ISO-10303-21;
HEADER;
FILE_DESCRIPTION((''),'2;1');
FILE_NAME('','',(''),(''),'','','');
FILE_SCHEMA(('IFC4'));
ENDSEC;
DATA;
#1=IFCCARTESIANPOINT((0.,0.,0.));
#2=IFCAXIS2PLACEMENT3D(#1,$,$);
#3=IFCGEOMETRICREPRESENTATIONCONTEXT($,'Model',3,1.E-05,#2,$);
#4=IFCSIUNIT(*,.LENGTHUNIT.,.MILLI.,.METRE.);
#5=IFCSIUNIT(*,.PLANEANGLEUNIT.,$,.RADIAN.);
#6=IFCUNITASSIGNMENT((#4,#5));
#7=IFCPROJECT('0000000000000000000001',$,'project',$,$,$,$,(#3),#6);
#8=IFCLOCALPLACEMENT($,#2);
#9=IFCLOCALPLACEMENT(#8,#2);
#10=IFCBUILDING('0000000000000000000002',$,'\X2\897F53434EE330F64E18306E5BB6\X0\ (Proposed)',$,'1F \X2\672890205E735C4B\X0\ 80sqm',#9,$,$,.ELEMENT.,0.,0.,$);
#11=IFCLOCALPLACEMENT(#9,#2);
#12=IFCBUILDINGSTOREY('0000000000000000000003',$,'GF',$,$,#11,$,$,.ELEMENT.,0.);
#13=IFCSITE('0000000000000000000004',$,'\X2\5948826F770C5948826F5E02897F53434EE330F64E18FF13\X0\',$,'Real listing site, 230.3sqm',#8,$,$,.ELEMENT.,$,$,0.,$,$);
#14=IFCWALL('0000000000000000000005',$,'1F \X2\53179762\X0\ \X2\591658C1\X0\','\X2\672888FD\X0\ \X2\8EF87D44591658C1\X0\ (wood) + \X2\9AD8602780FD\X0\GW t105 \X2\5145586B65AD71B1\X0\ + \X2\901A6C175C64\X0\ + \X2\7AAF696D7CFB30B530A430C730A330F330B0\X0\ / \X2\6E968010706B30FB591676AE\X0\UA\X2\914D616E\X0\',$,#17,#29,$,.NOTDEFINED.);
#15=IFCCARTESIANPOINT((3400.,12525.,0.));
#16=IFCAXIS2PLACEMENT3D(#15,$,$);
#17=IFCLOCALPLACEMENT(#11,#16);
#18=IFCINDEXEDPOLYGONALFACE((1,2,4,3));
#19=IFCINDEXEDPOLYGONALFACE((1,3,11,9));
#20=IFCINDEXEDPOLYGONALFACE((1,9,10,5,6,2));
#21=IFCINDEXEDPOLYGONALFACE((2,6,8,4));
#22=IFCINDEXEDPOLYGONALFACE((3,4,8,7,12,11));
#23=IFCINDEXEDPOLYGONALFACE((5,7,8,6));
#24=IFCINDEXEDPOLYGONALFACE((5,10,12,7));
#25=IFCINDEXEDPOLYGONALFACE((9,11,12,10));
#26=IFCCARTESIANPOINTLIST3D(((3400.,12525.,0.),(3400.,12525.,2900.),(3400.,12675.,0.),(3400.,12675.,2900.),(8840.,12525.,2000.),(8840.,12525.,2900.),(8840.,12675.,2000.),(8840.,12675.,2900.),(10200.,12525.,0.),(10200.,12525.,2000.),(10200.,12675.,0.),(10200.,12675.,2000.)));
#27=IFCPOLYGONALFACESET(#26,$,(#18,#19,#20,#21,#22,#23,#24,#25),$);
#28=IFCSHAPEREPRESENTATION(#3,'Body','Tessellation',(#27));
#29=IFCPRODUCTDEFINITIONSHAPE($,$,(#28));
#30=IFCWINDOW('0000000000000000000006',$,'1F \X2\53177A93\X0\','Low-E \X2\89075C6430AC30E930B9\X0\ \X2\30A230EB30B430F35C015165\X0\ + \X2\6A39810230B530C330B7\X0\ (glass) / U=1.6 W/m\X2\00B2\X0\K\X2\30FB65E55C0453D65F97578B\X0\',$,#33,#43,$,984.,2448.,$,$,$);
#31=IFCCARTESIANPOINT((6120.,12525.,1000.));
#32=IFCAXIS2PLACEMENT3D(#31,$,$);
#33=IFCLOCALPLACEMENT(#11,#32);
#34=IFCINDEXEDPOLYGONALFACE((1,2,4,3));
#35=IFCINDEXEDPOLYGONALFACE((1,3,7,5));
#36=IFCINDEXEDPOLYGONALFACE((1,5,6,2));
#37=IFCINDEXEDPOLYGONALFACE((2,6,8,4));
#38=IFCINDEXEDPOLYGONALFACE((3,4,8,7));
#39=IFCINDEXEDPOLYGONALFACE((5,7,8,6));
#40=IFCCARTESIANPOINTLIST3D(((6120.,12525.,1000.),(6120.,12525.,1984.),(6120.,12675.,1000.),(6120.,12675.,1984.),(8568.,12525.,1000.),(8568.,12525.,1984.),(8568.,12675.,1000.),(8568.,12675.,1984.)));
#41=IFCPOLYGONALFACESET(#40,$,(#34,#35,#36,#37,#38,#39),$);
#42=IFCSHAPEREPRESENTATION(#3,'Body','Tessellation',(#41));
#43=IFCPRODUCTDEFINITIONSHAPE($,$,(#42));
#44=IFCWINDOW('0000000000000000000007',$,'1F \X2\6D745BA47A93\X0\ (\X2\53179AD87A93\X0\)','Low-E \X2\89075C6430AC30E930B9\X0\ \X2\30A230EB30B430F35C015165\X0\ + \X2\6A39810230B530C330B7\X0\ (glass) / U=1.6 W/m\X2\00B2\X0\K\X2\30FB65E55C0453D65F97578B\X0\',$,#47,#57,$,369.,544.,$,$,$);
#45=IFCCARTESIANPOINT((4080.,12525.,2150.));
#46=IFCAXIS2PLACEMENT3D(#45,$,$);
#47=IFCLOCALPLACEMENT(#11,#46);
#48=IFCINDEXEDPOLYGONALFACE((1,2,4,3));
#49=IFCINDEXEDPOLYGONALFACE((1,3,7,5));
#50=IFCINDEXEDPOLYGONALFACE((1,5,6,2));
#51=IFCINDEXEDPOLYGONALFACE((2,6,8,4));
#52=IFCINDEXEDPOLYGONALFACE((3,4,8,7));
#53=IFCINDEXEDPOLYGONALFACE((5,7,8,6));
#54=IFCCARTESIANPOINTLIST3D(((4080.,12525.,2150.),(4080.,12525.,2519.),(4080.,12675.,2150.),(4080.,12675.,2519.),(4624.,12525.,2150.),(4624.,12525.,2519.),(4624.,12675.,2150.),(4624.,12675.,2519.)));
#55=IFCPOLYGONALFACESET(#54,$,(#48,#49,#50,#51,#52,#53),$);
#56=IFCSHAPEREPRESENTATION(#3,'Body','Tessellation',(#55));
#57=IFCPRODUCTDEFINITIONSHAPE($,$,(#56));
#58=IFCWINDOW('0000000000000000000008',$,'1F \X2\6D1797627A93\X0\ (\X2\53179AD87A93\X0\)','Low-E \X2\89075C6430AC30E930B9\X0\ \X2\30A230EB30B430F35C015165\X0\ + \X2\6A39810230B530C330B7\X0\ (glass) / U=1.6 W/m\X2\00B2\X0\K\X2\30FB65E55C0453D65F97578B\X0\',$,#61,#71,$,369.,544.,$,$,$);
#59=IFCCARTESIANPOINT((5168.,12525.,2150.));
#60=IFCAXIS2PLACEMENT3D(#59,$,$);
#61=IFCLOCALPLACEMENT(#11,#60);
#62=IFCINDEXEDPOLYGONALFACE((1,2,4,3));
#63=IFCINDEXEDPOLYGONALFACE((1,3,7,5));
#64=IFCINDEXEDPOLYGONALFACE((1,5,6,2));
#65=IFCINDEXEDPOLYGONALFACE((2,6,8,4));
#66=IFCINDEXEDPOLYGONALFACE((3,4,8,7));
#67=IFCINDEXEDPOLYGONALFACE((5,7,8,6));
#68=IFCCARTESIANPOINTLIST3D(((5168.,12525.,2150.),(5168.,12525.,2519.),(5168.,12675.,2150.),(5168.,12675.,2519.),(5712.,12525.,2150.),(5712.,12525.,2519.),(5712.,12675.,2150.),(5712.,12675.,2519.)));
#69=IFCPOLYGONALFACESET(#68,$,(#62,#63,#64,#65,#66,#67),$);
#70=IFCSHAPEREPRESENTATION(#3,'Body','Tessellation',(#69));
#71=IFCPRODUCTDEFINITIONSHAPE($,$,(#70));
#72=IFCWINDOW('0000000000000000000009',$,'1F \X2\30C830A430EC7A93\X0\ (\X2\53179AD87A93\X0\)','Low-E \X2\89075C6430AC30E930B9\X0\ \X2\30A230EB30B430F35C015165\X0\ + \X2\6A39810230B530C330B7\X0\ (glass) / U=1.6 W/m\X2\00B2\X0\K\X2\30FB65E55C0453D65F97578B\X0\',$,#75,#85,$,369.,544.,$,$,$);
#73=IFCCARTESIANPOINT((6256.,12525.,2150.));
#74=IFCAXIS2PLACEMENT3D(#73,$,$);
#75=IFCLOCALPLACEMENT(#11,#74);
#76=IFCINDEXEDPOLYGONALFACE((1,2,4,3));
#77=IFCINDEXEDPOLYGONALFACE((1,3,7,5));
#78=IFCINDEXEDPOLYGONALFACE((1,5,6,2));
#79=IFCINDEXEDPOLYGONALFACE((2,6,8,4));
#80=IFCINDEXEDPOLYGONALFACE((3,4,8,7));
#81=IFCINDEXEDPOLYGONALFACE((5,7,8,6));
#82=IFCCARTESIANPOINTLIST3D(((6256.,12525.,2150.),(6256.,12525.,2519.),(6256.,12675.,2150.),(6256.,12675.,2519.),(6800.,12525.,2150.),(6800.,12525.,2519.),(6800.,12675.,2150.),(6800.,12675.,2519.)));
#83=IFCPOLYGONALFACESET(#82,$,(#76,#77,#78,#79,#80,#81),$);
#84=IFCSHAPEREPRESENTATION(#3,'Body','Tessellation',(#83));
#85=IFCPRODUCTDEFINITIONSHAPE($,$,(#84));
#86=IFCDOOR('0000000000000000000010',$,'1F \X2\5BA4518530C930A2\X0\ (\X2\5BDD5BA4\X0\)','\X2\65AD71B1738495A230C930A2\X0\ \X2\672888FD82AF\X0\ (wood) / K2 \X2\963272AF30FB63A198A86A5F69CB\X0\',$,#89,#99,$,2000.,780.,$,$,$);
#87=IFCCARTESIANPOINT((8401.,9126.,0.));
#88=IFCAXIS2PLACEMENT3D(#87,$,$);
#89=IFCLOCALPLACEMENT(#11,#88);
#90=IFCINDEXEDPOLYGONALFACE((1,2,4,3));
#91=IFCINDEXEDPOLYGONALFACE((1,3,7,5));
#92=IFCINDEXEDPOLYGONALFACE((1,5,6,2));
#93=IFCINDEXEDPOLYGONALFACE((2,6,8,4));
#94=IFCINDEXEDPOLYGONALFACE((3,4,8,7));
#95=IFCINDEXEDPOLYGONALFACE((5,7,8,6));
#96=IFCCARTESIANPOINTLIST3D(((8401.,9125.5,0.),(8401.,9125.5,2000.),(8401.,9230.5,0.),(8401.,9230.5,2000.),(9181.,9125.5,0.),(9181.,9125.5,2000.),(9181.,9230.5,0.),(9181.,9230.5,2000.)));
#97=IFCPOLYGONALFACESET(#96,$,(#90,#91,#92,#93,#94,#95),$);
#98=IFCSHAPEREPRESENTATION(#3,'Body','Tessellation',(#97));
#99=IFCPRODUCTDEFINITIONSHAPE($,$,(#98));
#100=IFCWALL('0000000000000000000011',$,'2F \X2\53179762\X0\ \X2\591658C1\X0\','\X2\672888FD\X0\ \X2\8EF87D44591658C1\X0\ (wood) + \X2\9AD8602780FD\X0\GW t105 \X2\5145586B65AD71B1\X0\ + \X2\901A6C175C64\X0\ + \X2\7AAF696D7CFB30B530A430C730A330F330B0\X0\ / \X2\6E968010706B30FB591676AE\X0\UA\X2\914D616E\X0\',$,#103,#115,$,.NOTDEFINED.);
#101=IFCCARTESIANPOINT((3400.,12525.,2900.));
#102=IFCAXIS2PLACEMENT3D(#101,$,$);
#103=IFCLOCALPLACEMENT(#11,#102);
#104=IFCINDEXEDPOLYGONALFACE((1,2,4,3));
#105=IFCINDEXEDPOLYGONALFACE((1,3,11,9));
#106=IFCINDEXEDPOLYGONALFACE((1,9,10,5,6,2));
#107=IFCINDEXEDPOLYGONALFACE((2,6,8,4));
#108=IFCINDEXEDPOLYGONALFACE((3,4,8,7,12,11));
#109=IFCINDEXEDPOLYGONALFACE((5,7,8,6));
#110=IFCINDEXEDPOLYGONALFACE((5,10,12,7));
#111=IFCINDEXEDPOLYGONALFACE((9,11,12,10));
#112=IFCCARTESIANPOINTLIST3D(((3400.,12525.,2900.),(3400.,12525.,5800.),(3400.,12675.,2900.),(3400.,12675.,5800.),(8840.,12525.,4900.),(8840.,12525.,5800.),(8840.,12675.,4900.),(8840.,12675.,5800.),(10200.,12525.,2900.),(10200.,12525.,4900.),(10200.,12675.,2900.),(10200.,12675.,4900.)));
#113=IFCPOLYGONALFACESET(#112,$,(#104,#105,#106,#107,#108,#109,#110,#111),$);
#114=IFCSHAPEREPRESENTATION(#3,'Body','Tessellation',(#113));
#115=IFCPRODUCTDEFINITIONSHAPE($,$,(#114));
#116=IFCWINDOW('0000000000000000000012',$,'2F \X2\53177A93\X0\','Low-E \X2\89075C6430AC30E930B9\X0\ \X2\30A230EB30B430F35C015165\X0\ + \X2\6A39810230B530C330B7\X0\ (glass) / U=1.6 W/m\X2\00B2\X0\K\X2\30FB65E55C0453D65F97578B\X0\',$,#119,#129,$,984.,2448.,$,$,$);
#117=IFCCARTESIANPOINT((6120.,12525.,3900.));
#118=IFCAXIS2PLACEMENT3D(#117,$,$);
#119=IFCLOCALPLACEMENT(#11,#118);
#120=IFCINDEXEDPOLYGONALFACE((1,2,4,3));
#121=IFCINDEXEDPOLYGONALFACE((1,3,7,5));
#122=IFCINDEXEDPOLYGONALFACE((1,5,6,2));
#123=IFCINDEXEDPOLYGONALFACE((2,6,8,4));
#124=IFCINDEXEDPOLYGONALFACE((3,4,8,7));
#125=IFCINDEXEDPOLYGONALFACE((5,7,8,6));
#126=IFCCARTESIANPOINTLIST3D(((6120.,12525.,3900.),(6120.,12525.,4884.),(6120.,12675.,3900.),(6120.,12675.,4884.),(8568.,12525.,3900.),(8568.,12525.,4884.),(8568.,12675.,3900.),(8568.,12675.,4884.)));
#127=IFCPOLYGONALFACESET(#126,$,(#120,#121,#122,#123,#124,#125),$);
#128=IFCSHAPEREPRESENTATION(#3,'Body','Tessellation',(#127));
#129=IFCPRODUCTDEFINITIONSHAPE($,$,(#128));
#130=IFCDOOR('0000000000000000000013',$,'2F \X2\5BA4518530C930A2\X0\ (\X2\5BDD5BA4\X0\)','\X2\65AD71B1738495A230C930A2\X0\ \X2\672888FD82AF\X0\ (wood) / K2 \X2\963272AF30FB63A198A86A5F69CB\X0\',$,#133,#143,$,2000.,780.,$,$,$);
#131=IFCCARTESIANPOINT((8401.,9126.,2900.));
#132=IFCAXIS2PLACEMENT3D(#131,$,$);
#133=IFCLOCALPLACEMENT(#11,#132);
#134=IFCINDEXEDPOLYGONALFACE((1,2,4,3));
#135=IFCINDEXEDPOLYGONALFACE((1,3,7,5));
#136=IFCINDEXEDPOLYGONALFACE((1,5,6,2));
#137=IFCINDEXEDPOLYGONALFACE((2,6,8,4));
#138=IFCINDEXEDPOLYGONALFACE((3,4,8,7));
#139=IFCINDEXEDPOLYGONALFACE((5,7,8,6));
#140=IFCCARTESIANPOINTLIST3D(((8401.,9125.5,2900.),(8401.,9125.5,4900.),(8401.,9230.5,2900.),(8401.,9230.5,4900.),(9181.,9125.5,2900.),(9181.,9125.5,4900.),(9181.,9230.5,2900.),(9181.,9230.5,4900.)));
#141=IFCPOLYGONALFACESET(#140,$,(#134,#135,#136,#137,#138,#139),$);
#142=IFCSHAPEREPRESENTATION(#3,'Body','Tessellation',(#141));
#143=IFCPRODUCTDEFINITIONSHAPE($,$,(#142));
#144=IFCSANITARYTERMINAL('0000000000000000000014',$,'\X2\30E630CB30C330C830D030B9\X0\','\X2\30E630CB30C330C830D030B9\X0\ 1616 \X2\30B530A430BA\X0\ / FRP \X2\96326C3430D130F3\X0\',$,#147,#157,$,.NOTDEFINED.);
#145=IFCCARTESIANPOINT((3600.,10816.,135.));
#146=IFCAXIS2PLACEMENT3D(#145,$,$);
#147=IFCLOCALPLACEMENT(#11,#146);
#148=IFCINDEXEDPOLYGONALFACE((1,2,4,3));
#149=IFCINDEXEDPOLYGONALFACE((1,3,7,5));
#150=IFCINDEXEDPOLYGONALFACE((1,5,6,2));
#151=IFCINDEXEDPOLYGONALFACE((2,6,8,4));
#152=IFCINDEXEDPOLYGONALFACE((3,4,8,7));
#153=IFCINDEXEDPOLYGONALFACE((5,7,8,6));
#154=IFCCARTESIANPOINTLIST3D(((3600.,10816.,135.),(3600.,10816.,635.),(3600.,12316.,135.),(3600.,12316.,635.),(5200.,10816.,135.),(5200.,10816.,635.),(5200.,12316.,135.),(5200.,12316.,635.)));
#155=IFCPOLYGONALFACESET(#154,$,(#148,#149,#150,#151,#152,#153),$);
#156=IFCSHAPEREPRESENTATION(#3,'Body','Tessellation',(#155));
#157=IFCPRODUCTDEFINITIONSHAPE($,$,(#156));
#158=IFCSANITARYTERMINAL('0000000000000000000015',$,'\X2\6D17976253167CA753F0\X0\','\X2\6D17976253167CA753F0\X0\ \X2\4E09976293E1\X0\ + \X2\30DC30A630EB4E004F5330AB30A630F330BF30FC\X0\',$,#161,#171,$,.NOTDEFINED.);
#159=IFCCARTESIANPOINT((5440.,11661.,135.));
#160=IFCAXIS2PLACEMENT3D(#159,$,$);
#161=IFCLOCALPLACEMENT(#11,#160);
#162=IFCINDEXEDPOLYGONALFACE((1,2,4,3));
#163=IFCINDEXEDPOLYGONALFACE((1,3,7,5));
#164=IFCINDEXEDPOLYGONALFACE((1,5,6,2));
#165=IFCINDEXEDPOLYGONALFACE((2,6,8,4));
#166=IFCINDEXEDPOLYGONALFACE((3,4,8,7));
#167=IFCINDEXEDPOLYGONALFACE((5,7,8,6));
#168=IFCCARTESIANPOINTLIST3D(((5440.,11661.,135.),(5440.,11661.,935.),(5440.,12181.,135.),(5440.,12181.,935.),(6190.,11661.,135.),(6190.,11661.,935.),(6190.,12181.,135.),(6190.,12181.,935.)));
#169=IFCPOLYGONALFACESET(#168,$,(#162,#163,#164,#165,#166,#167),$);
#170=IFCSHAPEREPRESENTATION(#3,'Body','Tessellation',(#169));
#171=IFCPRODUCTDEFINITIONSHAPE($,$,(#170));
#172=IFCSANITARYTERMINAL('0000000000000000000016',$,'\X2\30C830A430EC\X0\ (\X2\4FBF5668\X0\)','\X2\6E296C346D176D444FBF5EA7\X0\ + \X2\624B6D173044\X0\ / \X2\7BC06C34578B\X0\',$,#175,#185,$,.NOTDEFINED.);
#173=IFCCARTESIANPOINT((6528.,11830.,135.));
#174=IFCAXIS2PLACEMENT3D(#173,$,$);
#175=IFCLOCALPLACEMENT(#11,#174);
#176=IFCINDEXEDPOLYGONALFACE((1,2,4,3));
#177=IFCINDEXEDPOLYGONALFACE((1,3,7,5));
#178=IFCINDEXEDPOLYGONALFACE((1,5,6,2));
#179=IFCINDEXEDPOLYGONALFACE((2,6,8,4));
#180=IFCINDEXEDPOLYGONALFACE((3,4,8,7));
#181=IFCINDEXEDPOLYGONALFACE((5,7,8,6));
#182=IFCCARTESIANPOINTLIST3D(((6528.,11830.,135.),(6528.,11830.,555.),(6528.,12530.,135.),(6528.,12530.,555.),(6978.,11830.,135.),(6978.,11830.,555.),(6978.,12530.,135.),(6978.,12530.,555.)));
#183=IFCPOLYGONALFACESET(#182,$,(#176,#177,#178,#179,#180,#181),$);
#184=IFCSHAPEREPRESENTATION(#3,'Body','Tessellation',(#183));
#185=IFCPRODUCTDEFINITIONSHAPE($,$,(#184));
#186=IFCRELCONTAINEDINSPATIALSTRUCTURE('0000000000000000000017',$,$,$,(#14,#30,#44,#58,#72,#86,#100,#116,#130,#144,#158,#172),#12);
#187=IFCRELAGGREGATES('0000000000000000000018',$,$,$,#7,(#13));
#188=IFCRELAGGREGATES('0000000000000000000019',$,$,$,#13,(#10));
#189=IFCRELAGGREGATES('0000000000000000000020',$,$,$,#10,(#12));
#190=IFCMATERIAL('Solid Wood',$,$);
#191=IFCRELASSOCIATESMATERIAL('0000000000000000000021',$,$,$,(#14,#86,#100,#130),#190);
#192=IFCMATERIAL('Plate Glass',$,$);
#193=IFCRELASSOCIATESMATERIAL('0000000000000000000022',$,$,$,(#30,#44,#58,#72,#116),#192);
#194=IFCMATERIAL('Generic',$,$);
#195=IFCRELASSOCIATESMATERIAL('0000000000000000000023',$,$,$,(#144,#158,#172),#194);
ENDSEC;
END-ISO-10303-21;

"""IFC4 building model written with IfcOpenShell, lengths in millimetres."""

from ifc_helpers import new_model, si_unit, frame, frame_2d, origin, place, context, project, spatial, rectangle, extrude, material, element, fill, save


model = new_model("IFC4")

# Units and contexts
model_context = context("Model", 3, precision=1e-05, world=origin())
ifc_project = project(units=[si_unit("LENGTHUNIT", "METRE", prefix="MILLI"), si_unit("PLANEANGLEUNIT", "RADIAN")], contexts=[model_context])

# Site, building, storey
site_placement = place(None, origin())
site = spatial("IfcSite", under=ifc_project, at=site_placement, Name="奈良県奈良市西千代ヶ丘３", ObjectType="Real listing site, 230.3sqm", CompositionType="ELEMENT", RefElevation=0.0)
building_placement = place(site_placement, origin())
building = spatial("IfcBuilding", under=site, at=building_placement, Name="西千代ヶ丘の家 (Proposed)", ObjectType="1F 木造平屋 80sqm", CompositionType="ELEMENT", ElevationOfRefHeight=0.0, ElevationOfTerrain=0.0)
storey_placement = place(building_placement, origin())
storey = spatial("IfcBuildingStorey", under=building, at=storey_placement, Name="GF", CompositionType="ELEMENT", Elevation=0.0)

# Wall, openings, windows
ifc_material_1 = material(Name="Solid Wood")
wall_1_placement = place(storey_placement, frame((3400.0, 12525.0, 0.0)))
wall_1 = element("IfcWall", 1, at=wall_1_placement, inside=storey, material=ifc_material_1, Name="1F 北面 外壁", Description="木製 軸組外壁 (wood) + 高性能GW t105 充填断熱 + 通気層 + 窯業系サイディング / 準耐火・外皮UA配慮", PredefinedType="NOTDEFINED", context=model_context, shape_type="SweptSolid", body=[
    extrude(rectangle(XDim=6800.0, YDim=150.0, at=frame_2d((3400.0, 75.0))), frame((3400.0, 12525.0, 0.0)), (0.0, 0.0, 1.0), 2900.0),
])
opening_1_placement = place(storey_placement, frame((6120.0, 12525.0, 1000.0)))
opening_1 = element("IfcOpeningElement", 2, at=opening_1_placement, cuts=wall_1, PredefinedType="NOTDEFINED", context=model_context, shape_type="SweptSolid", body=[
    extrude(rectangle(XDim=2448.0, YDim=150.0, at=frame_2d((1224.0, 75.0))), frame((6120.0, 12525.0, 1000.0)), (0.0, 0.0, 1.0), 984.0),
])
opening_2_placement = place(storey_placement, frame((4080.0, 12525.0, 2150.0)))
opening_2 = element("IfcOpeningElement", 3, at=opening_2_placement, cuts=wall_1, PredefinedType="NOTDEFINED", context=model_context, shape_type="SweptSolid", body=[
    extrude(rectangle(XDim=544.0, YDim=150.0, at=frame_2d((272.0, 75.0))), frame((4080.0, 12525.0, 2150.0)), (0.0, 0.0, 1.0), 369.0),
])
opening_3_placement = place(storey_placement, frame((5168.0, 12525.0, 2150.0)))
opening_3 = element("IfcOpeningElement", 4, at=opening_3_placement, cuts=wall_1, PredefinedType="NOTDEFINED", context=model_context, shape_type="SweptSolid", body=[
    extrude(rectangle(XDim=544.0, YDim=150.0, at=frame_2d((272.0, 75.0))), frame((5168.0, 12525.0, 2150.0)), (0.0, 0.0, 1.0), 369.0),
])
opening_4_placement = place(storey_placement, frame((6256.0, 12525.0, 2150.0)))
opening_4 = element("IfcOpeningElement", 5, at=opening_4_placement, cuts=wall_1, PredefinedType="NOTDEFINED", context=model_context, shape_type="SweptSolid", body=[
    extrude(rectangle(XDim=544.0, YDim=150.0, at=frame_2d((272.0, 75.0))), frame((6256.0, 12525.0, 2150.0)), (0.0, 0.0, 1.0), 369.0),
])
ifc_material_2 = material(Name="Plate Glass")
window_1_placement = place(storey_placement, frame((6120.0, 12525.0, 1000.0)))
window_1 = element("IfcWindow", 6, at=window_1_placement, inside=storey, material=ifc_material_2, Name="1F 北窓", Description="Low-E 複層ガラス アルゴン封入 + 樹脂サッシ (glass) / U=1.6 W/m²K・日射取得型", OverallHeight=984.0, OverallWidth=2448.0, context=model_context, shape_type="SweptSolid", body=[
    extrude(rectangle(XDim=2448.0, YDim=150.0, at=frame_2d((1224.0, 75.0))), frame((6120.0, 12525.0, 1000.0)), (0.0, 0.0, 1.0), 984.0),
])
fill(opening_1, window_1)
window_2_placement = place(storey_placement, frame((4080.0, 12525.0, 2150.0)))
window_2 = element("IfcWindow", 7, at=window_2_placement, inside=storey, material=ifc_material_2, Name="1F 浴室窓 (北高窓)", Description="Low-E 複層ガラス アルゴン封入 + 樹脂サッシ (glass) / U=1.6 W/m²K・日射取得型", OverallHeight=369.0, OverallWidth=544.0, context=model_context, shape_type="SweptSolid", body=[
    extrude(rectangle(XDim=544.0, YDim=150.0, at=frame_2d((272.0, 75.0))), frame((4080.0, 12525.0, 2150.0)), (0.0, 0.0, 1.0), 369.0),
])
fill(opening_2, window_2)
window_3_placement = place(storey_placement, frame((5168.0, 12525.0, 2150.0)))
window_3 = element("IfcWindow", 8, at=window_3_placement, inside=storey, material=ifc_material_2, Name="1F 洗面窓 (北高窓)", Description="Low-E 複層ガラス アルゴン封入 + 樹脂サッシ (glass) / U=1.6 W/m²K・日射取得型", OverallHeight=369.0, OverallWidth=544.0, context=model_context, shape_type="SweptSolid", body=[
    extrude(rectangle(XDim=544.0, YDim=150.0, at=frame_2d((272.0, 75.0))), frame((5168.0, 12525.0, 2150.0)), (0.0, 0.0, 1.0), 369.0),
])
fill(opening_3, window_3)
window_4_placement = place(storey_placement, frame((6256.0, 12525.0, 2150.0)))
window_4 = element("IfcWindow", 9, at=window_4_placement, inside=storey, material=ifc_material_2, Name="1F トイレ窓 (北高窓)", Description="Low-E 複層ガラス アルゴン封入 + 樹脂サッシ (glass) / U=1.6 W/m²K・日射取得型", OverallHeight=369.0, OverallWidth=544.0, context=model_context, shape_type="SweptSolid", body=[
    extrude(rectangle(XDim=544.0, YDim=150.0, at=frame_2d((272.0, 75.0))), frame((6256.0, 12525.0, 2150.0)), (0.0, 0.0, 1.0), 369.0),
])
fill(opening_4, window_4)

# Door
door_1_placement = place(storey_placement, frame((8401.0, 9126.0, 0.0)))
element("IfcDoor", 10, at=door_1_placement, inside=storey, material=ifc_material_1, Name="1F 室内ドア (寝室)", Description="断熱玄関ドア 木製芯 (wood) / K2 防犯・採風機構", OverallHeight=2000.0, OverallWidth=780.0, context=model_context, shape_type="SweptSolid", body=[
    extrude(rectangle(XDim=780.0, YDim=105.0, at=frame_2d((390.0, 52.0))), frame((8401.0, 9126.0, 0.0)), (0.0, 0.0, 1.0), 2000.0),
])

# Wall, opening, window
wall_2_placement = place(storey_placement, frame((3400.0, 12525.0, 2900.0)))
wall_2 = element("IfcWall", 11, at=wall_2_placement, inside=storey, material=ifc_material_1, Name="2F 北面 外壁", Description="木製 軸組外壁 (wood) + 高性能GW t105 充填断熱 + 通気層 + 窯業系サイディング / 準耐火・外皮UA配慮", PredefinedType="NOTDEFINED", context=model_context, shape_type="SweptSolid", body=[
    extrude(rectangle(XDim=6800.0, YDim=150.0, at=frame_2d((3400.0, 75.0))), frame((3400.0, 12525.0, 2900.0)), (0.0, 0.0, 1.0), 2900.0),
])
opening_5_placement = place(storey_placement, frame((6120.0, 12525.0, 3900.0)))
opening_5 = element("IfcOpeningElement", 12, at=opening_5_placement, cuts=wall_2, PredefinedType="NOTDEFINED", context=model_context, shape_type="SweptSolid", body=[
    extrude(rectangle(XDim=2448.0, YDim=150.0, at=frame_2d((1224.0, 75.0))), frame((6120.0, 12525.0, 3900.0)), (0.0, 0.0, 1.0), 984.0),
])
window_5_placement = place(storey_placement, frame((6120.0, 12525.0, 3900.0)))
window_5 = element("IfcWindow", 13, at=window_5_placement, inside=storey, material=ifc_material_2, Name="2F 北窓", Description="Low-E 複層ガラス アルゴン封入 + 樹脂サッシ (glass) / U=1.6 W/m²K・日射取得型", OverallHeight=984.0, OverallWidth=2448.0, context=model_context, shape_type="SweptSolid", body=[
    extrude(rectangle(XDim=2448.0, YDim=150.0, at=frame_2d((1224.0, 75.0))), frame((6120.0, 12525.0, 3900.0)), (0.0, 0.0, 1.0), 984.0),
])
fill(opening_5, window_5)

# Door
door_2_placement = place(storey_placement, frame((8401.0, 9126.0, 2900.0)))
element("IfcDoor", 14, at=door_2_placement, inside=storey, material=ifc_material_1, Name="2F 室内ドア (寝室)", Description="断熱玄関ドア 木製芯 (wood) / K2 防犯・採風機構", OverallHeight=2000.0, OverallWidth=780.0, context=model_context, shape_type="SweptSolid", body=[
    extrude(rectangle(XDim=780.0, YDim=105.0, at=frame_2d((390.0, 52.0))), frame((8401.0, 9126.0, 2900.0)), (0.0, 0.0, 1.0), 2000.0),
])

# Sanitary terminals
ifc_material_3 = material(Name="Generic")
sanitary_terminal_1_placement = place(storey_placement, frame((3600.0, 10816.0, 135.0)))
element("IfcSanitaryTerminal", 15, at=sanitary_terminal_1_placement, inside=storey, material=ifc_material_3, Name="ユニットバス", Description="ユニットバス 1616 サイズ / FRP 防水パン", PredefinedType="NOTDEFINED", context=model_context, shape_type="SweptSolid", body=[
    extrude(rectangle(XDim=1600.0, YDim=1500.0, at=frame_2d((800.0, 750.0))), frame((3600.0, 10816.0, 135.0)), (0.0, 0.0, 1.0), 500.0),
])
sanitary_terminal_2_placement = place(storey_placement, frame((5440.0, 11661.0, 135.0)))
element("IfcSanitaryTerminal", 16, at=sanitary_terminal_2_placement, inside=storey, material=ifc_material_3, Name="洗面化粧台", Description="洗面化粧台 三面鏡 + ボウル一体カウンター", PredefinedType="NOTDEFINED", context=model_context, shape_type="SweptSolid", body=[
    extrude(rectangle(XDim=750.0, YDim=520.0, at=frame_2d((375.0, 260.0))), frame((5440.0, 11661.0, 135.0)), (0.0, 0.0, 1.0), 800.0),
])
sanitary_terminal_3_placement = place(storey_placement, frame((6528.0, 11830.0, 135.0)))
element("IfcSanitaryTerminal", 17, at=sanitary_terminal_3_placement, inside=storey, material=ifc_material_3, Name="トイレ (便器)", Description="温水洗浄便座 + 手洗い / 節水型", PredefinedType="NOTDEFINED", context=model_context, shape_type="SweptSolid", body=[
    extrude(rectangle(XDim=450.0, YDim=700.0, at=frame_2d((225.0, 350.0))), frame((6528.0, 11830.0, 135.0)), (0.0, 0.0, 1.0), 420.0),
])

save(model, "model.ifc")
